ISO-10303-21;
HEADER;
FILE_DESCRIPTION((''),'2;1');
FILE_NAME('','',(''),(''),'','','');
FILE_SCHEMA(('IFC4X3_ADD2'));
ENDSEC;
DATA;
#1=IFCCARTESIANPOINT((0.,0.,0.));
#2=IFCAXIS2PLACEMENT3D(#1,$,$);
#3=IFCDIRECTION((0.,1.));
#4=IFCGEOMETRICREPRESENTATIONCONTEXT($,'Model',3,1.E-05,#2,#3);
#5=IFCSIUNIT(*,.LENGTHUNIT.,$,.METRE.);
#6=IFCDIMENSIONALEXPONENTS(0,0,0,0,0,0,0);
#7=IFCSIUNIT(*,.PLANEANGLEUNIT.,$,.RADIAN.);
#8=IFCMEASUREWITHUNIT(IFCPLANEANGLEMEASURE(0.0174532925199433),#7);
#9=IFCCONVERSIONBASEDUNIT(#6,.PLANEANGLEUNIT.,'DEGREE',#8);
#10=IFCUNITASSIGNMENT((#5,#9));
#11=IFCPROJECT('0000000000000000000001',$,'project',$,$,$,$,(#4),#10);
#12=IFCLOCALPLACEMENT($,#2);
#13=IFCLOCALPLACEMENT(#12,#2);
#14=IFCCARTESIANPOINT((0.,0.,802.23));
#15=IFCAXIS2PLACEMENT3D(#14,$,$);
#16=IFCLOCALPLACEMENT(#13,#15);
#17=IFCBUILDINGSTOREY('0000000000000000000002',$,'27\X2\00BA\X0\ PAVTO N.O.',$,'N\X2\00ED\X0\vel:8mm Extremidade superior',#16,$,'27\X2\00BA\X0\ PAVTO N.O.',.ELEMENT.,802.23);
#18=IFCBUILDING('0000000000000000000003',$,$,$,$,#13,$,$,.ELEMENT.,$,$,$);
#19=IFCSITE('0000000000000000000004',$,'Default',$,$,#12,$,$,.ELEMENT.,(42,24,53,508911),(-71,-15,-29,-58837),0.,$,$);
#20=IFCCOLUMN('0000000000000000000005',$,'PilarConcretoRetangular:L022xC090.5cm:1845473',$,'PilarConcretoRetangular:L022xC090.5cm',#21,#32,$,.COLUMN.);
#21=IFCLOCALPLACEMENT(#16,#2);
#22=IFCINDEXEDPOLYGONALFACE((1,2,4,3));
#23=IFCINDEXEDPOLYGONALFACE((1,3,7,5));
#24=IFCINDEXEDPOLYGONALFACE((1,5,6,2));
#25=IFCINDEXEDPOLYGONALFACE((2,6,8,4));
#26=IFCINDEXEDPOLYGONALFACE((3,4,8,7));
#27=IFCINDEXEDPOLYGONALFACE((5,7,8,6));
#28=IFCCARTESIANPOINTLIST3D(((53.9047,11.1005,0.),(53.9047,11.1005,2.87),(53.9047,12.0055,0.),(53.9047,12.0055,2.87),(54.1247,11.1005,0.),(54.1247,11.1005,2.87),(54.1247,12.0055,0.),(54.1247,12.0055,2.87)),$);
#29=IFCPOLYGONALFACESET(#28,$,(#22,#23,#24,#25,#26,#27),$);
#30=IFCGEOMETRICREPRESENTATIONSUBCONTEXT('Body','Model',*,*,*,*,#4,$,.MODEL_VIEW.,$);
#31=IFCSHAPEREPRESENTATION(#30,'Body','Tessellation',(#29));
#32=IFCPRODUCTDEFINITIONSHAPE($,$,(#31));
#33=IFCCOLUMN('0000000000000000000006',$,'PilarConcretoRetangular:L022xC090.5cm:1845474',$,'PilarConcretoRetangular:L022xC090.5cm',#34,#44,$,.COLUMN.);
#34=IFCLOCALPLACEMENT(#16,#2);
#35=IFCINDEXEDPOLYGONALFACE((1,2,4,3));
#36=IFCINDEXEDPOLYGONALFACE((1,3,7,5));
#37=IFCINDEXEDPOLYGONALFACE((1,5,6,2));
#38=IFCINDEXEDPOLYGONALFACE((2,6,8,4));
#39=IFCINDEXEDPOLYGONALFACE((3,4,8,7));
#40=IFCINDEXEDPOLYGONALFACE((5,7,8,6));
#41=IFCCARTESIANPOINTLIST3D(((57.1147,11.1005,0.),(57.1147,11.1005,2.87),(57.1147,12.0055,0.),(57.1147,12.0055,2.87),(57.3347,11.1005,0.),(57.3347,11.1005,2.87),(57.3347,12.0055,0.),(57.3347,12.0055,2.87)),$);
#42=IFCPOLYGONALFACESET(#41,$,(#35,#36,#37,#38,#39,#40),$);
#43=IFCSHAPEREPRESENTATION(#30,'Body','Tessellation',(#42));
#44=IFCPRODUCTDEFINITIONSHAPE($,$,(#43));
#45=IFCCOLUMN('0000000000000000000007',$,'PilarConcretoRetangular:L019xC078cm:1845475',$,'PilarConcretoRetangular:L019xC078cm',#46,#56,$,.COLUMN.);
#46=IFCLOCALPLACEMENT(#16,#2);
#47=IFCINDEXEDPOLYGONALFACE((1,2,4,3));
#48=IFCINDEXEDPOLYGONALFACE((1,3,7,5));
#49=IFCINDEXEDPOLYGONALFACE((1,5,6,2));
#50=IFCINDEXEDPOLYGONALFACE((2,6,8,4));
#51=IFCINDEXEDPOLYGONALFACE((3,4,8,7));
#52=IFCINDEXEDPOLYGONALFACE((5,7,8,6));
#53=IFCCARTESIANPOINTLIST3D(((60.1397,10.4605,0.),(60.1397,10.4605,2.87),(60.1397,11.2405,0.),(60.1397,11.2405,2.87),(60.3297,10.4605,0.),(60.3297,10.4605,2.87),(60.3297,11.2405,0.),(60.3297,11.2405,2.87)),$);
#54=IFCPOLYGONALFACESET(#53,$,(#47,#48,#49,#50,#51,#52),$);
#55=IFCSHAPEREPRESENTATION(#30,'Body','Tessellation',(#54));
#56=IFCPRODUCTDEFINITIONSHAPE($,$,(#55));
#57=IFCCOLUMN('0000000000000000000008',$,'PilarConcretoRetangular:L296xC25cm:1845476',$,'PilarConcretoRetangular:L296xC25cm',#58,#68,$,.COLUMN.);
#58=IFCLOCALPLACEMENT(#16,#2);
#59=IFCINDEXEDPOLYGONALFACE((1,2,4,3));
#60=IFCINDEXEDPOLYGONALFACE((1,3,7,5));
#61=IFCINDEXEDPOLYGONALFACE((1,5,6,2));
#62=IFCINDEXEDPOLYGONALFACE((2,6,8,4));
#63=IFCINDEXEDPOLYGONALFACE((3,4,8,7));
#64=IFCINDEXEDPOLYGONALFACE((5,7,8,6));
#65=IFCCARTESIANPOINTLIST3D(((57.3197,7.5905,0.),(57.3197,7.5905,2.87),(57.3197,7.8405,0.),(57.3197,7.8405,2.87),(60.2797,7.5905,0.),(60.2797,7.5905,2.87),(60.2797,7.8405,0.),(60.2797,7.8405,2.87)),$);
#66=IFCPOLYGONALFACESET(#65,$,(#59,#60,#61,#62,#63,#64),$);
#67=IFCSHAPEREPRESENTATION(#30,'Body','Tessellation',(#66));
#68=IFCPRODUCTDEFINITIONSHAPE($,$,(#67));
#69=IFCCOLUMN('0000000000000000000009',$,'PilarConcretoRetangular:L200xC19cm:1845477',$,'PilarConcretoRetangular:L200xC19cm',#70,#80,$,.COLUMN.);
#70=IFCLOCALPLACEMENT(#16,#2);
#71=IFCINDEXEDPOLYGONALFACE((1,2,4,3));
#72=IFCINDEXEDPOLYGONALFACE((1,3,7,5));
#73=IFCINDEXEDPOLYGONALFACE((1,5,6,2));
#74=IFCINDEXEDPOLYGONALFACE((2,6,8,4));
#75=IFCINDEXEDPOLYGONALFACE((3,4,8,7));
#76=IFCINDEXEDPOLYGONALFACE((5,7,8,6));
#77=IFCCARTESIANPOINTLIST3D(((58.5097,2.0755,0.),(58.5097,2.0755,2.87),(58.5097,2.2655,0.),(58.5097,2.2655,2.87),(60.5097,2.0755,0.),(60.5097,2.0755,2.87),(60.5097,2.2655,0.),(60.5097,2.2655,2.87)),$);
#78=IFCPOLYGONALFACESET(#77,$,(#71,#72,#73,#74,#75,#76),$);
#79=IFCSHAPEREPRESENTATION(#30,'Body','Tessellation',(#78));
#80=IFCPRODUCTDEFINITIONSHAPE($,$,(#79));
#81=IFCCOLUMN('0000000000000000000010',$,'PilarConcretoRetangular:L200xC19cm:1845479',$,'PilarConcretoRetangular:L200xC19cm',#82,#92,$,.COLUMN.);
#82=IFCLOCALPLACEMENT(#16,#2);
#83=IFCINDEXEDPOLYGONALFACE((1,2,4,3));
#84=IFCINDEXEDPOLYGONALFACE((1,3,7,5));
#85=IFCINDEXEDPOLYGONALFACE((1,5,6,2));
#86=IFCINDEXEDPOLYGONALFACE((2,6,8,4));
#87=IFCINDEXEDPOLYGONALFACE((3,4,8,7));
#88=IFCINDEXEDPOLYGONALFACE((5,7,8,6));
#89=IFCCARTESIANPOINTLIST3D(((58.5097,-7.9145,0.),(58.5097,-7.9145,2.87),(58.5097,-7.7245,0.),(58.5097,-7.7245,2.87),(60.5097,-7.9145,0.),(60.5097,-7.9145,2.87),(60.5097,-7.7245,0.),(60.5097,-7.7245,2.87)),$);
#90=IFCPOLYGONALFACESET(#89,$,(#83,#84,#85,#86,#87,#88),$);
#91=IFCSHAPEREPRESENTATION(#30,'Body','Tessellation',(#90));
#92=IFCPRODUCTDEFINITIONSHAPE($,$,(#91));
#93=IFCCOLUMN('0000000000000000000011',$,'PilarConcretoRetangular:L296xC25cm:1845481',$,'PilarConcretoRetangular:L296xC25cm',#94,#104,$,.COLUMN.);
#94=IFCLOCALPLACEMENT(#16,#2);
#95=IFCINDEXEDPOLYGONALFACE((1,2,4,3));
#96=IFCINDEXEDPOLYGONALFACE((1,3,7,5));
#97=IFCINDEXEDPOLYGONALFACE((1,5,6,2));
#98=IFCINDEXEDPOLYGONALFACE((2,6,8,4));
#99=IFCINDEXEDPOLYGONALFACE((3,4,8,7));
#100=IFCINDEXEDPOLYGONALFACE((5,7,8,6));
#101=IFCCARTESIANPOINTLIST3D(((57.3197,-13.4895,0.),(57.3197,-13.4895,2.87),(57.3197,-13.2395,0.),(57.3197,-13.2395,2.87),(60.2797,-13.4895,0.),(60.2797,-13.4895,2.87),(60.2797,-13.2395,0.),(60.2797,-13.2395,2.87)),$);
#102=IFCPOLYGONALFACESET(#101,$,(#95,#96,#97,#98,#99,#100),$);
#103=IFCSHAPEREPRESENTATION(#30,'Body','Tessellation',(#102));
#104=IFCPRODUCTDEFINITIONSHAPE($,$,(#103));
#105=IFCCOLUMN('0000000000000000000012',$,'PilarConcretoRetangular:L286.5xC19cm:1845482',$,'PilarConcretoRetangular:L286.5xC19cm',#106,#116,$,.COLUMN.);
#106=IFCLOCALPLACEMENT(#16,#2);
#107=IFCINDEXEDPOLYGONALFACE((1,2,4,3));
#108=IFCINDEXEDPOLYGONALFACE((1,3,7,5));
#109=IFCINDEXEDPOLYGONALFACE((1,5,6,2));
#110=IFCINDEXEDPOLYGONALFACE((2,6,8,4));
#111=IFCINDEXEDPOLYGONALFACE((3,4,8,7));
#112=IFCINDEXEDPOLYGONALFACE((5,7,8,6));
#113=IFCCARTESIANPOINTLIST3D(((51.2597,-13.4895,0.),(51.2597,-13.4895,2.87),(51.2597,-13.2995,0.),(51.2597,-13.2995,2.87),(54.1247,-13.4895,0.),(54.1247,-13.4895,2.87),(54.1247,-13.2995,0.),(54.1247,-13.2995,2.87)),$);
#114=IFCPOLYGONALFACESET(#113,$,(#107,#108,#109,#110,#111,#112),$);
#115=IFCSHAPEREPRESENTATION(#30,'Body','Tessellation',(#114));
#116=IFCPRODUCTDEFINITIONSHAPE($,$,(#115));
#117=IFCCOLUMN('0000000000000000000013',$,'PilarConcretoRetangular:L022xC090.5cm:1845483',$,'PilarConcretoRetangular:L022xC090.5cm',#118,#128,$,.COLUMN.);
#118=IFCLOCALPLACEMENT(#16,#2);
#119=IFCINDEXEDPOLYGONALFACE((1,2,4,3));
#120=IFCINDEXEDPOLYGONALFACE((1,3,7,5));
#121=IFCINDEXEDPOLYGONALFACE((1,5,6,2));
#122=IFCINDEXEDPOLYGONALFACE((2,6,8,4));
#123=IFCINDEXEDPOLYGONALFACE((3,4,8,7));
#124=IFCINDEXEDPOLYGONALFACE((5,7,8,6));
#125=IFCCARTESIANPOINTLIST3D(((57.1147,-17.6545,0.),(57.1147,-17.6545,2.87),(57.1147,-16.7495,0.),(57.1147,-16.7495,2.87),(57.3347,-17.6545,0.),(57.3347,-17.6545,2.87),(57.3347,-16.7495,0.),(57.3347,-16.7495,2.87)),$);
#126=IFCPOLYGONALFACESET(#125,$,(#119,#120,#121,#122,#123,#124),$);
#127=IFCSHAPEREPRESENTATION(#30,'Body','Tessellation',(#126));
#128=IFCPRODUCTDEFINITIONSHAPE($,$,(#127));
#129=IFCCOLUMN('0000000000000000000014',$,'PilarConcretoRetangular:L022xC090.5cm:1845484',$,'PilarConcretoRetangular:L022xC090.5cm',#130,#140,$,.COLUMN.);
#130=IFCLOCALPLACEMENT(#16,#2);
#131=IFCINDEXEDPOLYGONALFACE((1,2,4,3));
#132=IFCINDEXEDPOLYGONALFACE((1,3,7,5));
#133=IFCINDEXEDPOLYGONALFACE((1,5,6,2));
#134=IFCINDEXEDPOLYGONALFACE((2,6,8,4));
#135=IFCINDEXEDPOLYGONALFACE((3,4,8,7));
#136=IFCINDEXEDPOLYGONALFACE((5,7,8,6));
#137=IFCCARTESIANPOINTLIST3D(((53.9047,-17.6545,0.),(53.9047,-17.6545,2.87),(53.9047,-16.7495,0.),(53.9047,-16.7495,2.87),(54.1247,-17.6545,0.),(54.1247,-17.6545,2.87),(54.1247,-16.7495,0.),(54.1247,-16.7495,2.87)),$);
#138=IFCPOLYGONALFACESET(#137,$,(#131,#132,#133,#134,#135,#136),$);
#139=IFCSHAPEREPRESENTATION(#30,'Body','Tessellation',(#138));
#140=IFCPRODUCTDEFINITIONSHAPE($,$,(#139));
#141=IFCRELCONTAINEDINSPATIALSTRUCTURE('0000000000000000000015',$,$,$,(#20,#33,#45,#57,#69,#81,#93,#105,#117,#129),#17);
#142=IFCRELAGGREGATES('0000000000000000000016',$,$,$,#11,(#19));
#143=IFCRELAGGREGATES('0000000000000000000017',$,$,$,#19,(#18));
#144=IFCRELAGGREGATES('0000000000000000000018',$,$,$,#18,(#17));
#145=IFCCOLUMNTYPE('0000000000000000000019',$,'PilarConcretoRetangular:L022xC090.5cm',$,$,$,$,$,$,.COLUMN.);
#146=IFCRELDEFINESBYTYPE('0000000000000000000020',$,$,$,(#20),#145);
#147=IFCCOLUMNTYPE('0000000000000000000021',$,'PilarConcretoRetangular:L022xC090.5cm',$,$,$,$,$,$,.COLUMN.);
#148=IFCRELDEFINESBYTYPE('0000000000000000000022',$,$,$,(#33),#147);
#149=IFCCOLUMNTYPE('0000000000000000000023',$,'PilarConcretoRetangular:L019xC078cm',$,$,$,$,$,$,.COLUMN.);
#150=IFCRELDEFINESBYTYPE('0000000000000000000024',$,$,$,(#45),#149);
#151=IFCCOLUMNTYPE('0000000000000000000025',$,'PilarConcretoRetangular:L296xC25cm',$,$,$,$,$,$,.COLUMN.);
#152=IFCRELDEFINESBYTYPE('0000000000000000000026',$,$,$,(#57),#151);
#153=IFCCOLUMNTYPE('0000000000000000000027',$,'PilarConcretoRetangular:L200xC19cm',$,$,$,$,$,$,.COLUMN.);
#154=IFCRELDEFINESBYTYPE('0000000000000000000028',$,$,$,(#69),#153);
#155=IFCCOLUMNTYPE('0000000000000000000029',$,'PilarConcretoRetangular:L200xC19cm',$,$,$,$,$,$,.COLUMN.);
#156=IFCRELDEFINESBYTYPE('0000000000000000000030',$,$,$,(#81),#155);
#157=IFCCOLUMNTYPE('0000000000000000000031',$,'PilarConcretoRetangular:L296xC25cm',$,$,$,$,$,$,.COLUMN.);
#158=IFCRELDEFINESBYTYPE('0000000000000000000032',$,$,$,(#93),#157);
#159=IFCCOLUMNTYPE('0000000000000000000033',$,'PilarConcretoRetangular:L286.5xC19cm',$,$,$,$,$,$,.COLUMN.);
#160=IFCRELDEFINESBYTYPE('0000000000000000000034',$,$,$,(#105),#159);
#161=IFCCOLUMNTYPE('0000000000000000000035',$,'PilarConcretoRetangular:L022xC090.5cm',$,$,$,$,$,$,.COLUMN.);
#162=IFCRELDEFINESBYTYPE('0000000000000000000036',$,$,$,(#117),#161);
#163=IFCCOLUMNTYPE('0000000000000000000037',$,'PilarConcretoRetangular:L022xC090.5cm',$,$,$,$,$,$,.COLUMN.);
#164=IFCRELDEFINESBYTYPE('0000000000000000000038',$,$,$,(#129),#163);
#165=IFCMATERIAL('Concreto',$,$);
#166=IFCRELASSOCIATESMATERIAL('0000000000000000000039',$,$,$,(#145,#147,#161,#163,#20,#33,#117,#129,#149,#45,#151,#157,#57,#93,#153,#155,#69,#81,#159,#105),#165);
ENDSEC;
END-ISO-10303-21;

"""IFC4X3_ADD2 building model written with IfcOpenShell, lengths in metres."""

from ifc_helpers import new_model, entity, si_unit, converted_unit, direction, frame, frame_2d, origin, origin_2d_with_axis, place, context, subcontext, project, spatial, rectangle, extrude, source, transform, mapped, material, material_profile, profile_set, profile_usage, type_object, type_shapes, element, save


model = new_model("IFC4X3_ADD2")

# Units and contexts
model_context = context("Model", 3, precision=1e-05, world=origin(), true_north=direction((0.0, 1.0)))
body_context = subcontext(model_context, "Body", "Model", "MODEL_VIEW")
ifc_project = project(units=[si_unit("LENGTHUNIT", "METRE"), converted_unit("PLANEANGLEUNIT", "DEGREE", entity("IfcPlaneAngleMeasure", 0.0174532925199433), si_unit("PLANEANGLEUNIT", "RADIAN"), dimensions=[0, 0, 0, 0, 0, 0, 0])], contexts=[model_context])

# Site, building, storey
site_placement = place(None, origin())
site = spatial("IfcSite", under=ifc_project, at=site_placement, Name="Default", CompositionType="ELEMENT", RefLatitude=(42, 24, 53, 508911), RefLongitude=(-71, -15, -29, -58837), RefElevation=0.0)
building_placement = place(site_placement, origin())
building = spatial("IfcBuilding", under=site, at=building_placement, CompositionType="ELEMENT")
storey_placement = place(building_placement, frame((0.0, 0.0, 802.23)))
storey = spatial("IfcBuildingStorey", under=building, at=storey_placement, Name="27º PAVTO N.O.", ObjectType="Nível:8mm Extremidade superior", LongName="27º PAVTO N.O.", CompositionType="ELEMENT", Elevation=802.23)

# Columns
ifc_material = material(Name="Concreto")
ifc_material_profile_1 = material_profile(ifc_material, rectangle(XDim=0.22, YDim=0.905, at=frame_2d((0.0, 0.0), x_axis=(1.0, 0.0))), Name="L022xC090.5cm")
ifc_profile_set_1 = profile_set([ifc_material_profile_1], Name="L022xC090.5cm")
ifc_profile_usage_1 = profile_usage(ifc_profile_set_1)
ifc_material_profile_2 = material_profile(ifc_material, rectangle(XDim=2.0, YDim=0.19, at=frame_2d((0.0, 0.0), x_axis=(1.0, 0.0))), Name="L200xC19cm")
ifc_profile_set_2 = profile_set([ifc_material_profile_2], Name="L200xC19cm")
ifc_profile_usage_2 = profile_usage(ifc_profile_set_2)
ifc_material_profile_3 = material_profile(ifc_material, rectangle(XDim=2.96, YDim=0.25, at=frame_2d((0.0, 0.0), x_axis=(1.0, 0.0))), Name="L296xC25cm")
ifc_profile_set_3 = profile_set([ifc_material_profile_3], Name="L296xC25cm")
ifc_profile_usage_3 = profile_usage(ifc_profile_set_3)
ifc_material_profile_4 = material_profile(ifc_material, rectangle(XDim=2.865, YDim=0.19, at=frame_2d((0.0, 0.0), x_axis=(1.0, 0.0))), Name="L286.5xC19cm")
ifc_profile_set_4 = profile_set([ifc_material_profile_4], Name="L286.5xC19cm")
ifc_profile_usage_4 = profile_usage(ifc_profile_set_4)
column_type_1 = type_object("IfcColumnType", Name="PilarConcretoRetangular:L022xC090.5cm", PredefinedType="COLUMN", material=ifc_profile_set_1)
shared_shape_1 = source(origin(), body_context, "Body", "SweptSolid", [
    extrude(rectangle(XDim=0.22, YDim=0.905, at=frame_2d((0.0, 0.0), x_axis=(1.0, 0.0))), frame((54.0147, 11.553, 802.23)), (0.0, 0.0, 1.0), 2.87),
])
type_shapes(column_type_1, [shared_shape_1])
column_1_placement = place(storey_placement, frame((0.0, 0.0, -802.23)))
element("IfcColumn", 1, at=column_1_placement, inside=storey, type_object=column_type_1, material=ifc_profile_usage_1, Name="PilarConcretoRetangular:L022xC090.5cm:1845473", ObjectType="PilarConcretoRetangular:L022xC090.5cm", PredefinedType="COLUMN", context=body_context, shape_type="MappedRepresentation", body=[
    mapped(shared_shape_1, transform((0.0, 0.0, 0.0), scale=1.0)),
])
column_type_2 = type_object("IfcColumnType", Name="PilarConcretoRetangular:L022xC090.5cm", PredefinedType="COLUMN", material=ifc_profile_set_1)
shared_shape_2 = source(origin(), body_context, "Body", "SweptSolid", [
    extrude(rectangle(XDim=0.22, YDim=0.905, at=frame_2d((0.0, 0.0), x_axis=(1.0, 0.0))), frame((57.2247, 11.553, 802.23)), (0.0, 0.0, 1.0), 2.87),
])
type_shapes(column_type_2, [shared_shape_2])
column_2_placement = place(storey_placement, frame((0.0, 0.0, -802.23)))
element("IfcColumn", 2, at=column_2_placement, inside=storey, type_object=column_type_2, material=ifc_profile_usage_1, Name="PilarConcretoRetangular:L022xC090.5cm:1845474", ObjectType="PilarConcretoRetangular:L022xC090.5cm", PredefinedType="COLUMN", context=body_context, shape_type="MappedRepresentation", body=[
    mapped(shared_shape_2, transform((0.0, 0.0, 0.0), scale=1.0)),
])
ifc_material_profile_5 = material_profile(ifc_material, rectangle(XDim=0.19, YDim=0.78, at=frame_2d((0.0, 0.0), x_axis=(1.0, 0.0))), Name="L019xC078cm")
ifc_profile_set_5 = profile_set([ifc_material_profile_5], Name="L019xC078cm")
ifc_profile_usage_5 = profile_usage(ifc_profile_set_5)
column_type_3 = type_object("IfcColumnType", Name="PilarConcretoRetangular:L019xC078cm", PredefinedType="COLUMN", material=ifc_profile_set_5)
shared_shape_3 = source(origin(), body_context, "Body", "SweptSolid", [
    extrude(rectangle(XDim=0.19, YDim=0.78, at=frame_2d((0.0, 0.0), x_axis=(1.0, 0.0))), frame((60.2347, 10.8505, 802.23)), (0.0, 0.0, 1.0), 2.87),
])
type_shapes(column_type_3, [shared_shape_3])
column_3_placement = place(storey_placement, frame((0.0, 0.0, -802.23)))
element("IfcColumn", 3, at=column_3_placement, inside=storey, type_object=column_type_3, material=ifc_profile_usage_5, Name="PilarConcretoRetangular:L019xC078cm:1845475", ObjectType="PilarConcretoRetangular:L019xC078cm", PredefinedType="COLUMN", context=body_context, shape_type="MappedRepresentation", body=[
    mapped(shared_shape_3, transform((0.0, 0.0, 0.0), scale=1.0)),
])
column_type_4 = type_object("IfcColumnType", Name="PilarConcretoRetangular:L296xC25cm", PredefinedType="COLUMN", material=ifc_profile_set_3)
shared_shape_4 = source(origin(), body_context, "Body", "SweptSolid", [
    extrude(rectangle(XDim=2.96, YDim=0.25, at=frame_2d((0.0, 0.0), x_axis=(1.0, 0.0))), frame((58.7997, 7.7155, 802.23), z_axis=(0.0, 0.0, 1.0), x_axis=(-1.0, 0.0, 0.0)), (0.0, 0.0, 1.0), 2.87),
])
type_shapes(column_type_4, [shared_shape_4])
column_4_placement = place(storey_placement, frame((0.0, 0.0, -802.23)))
element("IfcColumn", 4, at=column_4_placement, inside=storey, type_object=column_type_4, material=ifc_profile_usage_3, Name="PilarConcretoRetangular:L296xC25cm:1845476", ObjectType="PilarConcretoRetangular:L296xC25cm", PredefinedType="COLUMN", context=body_context, shape_type="MappedRepresentation", body=[
    mapped(shared_shape_4, transform((0.0, 0.0, 0.0), scale=1.0)),
])
column_type_5 = type_object("IfcColumnType", Name="PilarConcretoRetangular:L200xC19cm", PredefinedType="COLUMN", material=ifc_profile_set_2)
shared_shape_5 = source(origin(), body_context, "Body", "SweptSolid", [
    extrude(rectangle(XDim=2.0, YDim=0.19, at=origin_2d_with_axis()), frame((59.5097, 2.1705, 802.23), z_axis=(0.0, 0.0, 1.0), x_axis=(-1.0, 0.0, 0.0)), (0.0, 0.0, 1.0), 2.87),
])
type_shapes(column_type_5, [shared_shape_5])
column_5_placement = place(storey_placement, frame((0.0, 0.0, -802.23)))
element("IfcColumn", 5, at=column_5_placement, inside=storey, type_object=column_type_5, material=ifc_profile_usage_2, Name="PilarConcretoRetangular:L200xC19cm:1845477", ObjectType="PilarConcretoRetangular:L200xC19cm", PredefinedType="COLUMN", context=body_context, shape_type="MappedRepresentation", body=[
    mapped(shared_shape_5, transform((0.0, 0.0, 0.0), scale=1.0)),
])
column_type_6 = type_object("IfcColumnType", Name="PilarConcretoRetangular:L200xC19cm", PredefinedType="COLUMN", material=ifc_profile_set_2)
shared_shape_6 = source(origin(), body_context, "Body", "SweptSolid", [
    extrude(rectangle(XDim=2.0, YDim=0.19, at=origin_2d_with_axis()), frame((59.5097, -7.8195, 802.23), z_axis=(0.0, 0.0, 1.0), x_axis=(-1.0, 0.0, 0.0)), (0.0, 0.0, 1.0), 2.87),
])
type_shapes(column_type_6, [shared_shape_6])
column_6_placement = place(storey_placement, frame((0.0, 0.0, -802.23)))
element("IfcColumn", 6, at=column_6_placement, inside=storey, type_object=column_type_6, material=ifc_profile_usage_2, Name="PilarConcretoRetangular:L200xC19cm:1845479", ObjectType="PilarConcretoRetangular:L200xC19cm", PredefinedType="COLUMN", context=body_context, shape_type="MappedRepresentation", body=[
    mapped(shared_shape_6, transform((0.0, 0.0, 0.0), scale=1.0)),
])
column_type_7 = type_object("IfcColumnType", Name="PilarConcretoRetangular:L296xC25cm", PredefinedType="COLUMN", material=ifc_profile_set_3)
shared_shape_7 = source(origin(), body_context, "Body", "SweptSolid", [
    extrude(rectangle(XDim=2.96, YDim=0.25, at=frame_2d((0.0, 0.0), x_axis=(1.0, 0.0))), frame((58.7997, -13.3645, 802.23), z_axis=(0.0, 0.0, 1.0), x_axis=(-1.0, 0.0, 0.0)), (0.0, 0.0, 1.0), 2.87),
])
type_shapes(column_type_7, [shared_shape_7])
column_7_placement = place(storey_placement, frame((0.0, 0.0, -802.23)))
element("IfcColumn", 7, at=column_7_placement, inside=storey, type_object=column_type_7, material=ifc_profile_usage_3, Name="PilarConcretoRetangular:L296xC25cm:1845481", ObjectType="PilarConcretoRetangular:L296xC25cm", PredefinedType="COLUMN", context=body_context, shape_type="MappedRepresentation", body=[
    mapped(shared_shape_7, transform((0.0, 0.0, 0.0), scale=1.0)),
])
column_type_8 = type_object("IfcColumnType", Name="PilarConcretoRetangular:L286.5xC19cm", PredefinedType="COLUMN", material=ifc_profile_set_4)
shared_shape_8 = source(origin(), body_context, "Body", "SweptSolid", [
    extrude(rectangle(XDim=2.865, YDim=0.19, at=frame_2d((0.0, 0.0), x_axis=(1.0, 0.0))), frame((52.6922, -13.3945, 802.23), z_axis=(0.0, 0.0, 1.0), x_axis=(-1.0, 0.0, 0.0)), (0.0, 0.0, 1.0), 2.87),
])
type_shapes(column_type_8, [shared_shape_8])
column_8_placement = place(storey_placement, frame((0.0, 0.0, -802.23)))
element("IfcColumn", 8, at=column_8_placement, inside=storey, type_object=column_type_8, material=ifc_profile_usage_4, Name="PilarConcretoRetangular:L286.5xC19cm:1845482", ObjectType="PilarConcretoRetangular:L286.5xC19cm", PredefinedType="COLUMN", context=body_context, shape_type="MappedRepresentation", body=[
    mapped(shared_shape_8, transform((0.0, 0.0, 0.0), scale=1.0)),
])
column_type_9 = type_object("IfcColumnType", Name="PilarConcretoRetangular:L022xC090.5cm", PredefinedType="COLUMN", material=ifc_profile_set_1)
shared_shape_9 = source(origin(), body_context, "Body", "SweptSolid", [
    extrude(rectangle(XDim=0.22, YDim=0.905, at=frame_2d((0.0, 0.0), x_axis=(1.0, 0.0))), frame((57.2247, -17.202, 802.23), z_axis=(0.0, 0.0, 1.0), x_axis=(-1.0, 0.0, 0.0)), (0.0, 0.0, 1.0), 2.87),
])
type_shapes(column_type_9, [shared_shape_9])
column_9_placement = place(storey_placement, frame((0.0, 0.0, -802.23)))
element("IfcColumn", 9, at=column_9_placement, inside=storey, type_object=column_type_9, material=ifc_profile_usage_1, Name="PilarConcretoRetangular:L022xC090.5cm:1845483", ObjectType="PilarConcretoRetangular:L022xC090.5cm", PredefinedType="COLUMN", context=body_context, shape_type="MappedRepresentation", body=[
    mapped(shared_shape_9, transform((0.0, 0.0, 0.0), scale=1.0)),
])
column_type_10 = type_object("IfcColumnType", Name="PilarConcretoRetangular:L022xC090.5cm", PredefinedType="COLUMN", material=ifc_profile_set_1)
shared_shape_10 = source(origin(), body_context, "Body", "SweptSolid", [
    extrude(rectangle(XDim=0.22, YDim=0.905, at=frame_2d((0.0, 0.0), x_axis=(1.0, 0.0))), frame((54.0147, -17.202, 802.23), z_axis=(0.0, 0.0, 1.0), x_axis=(-1.0, 0.0, 0.0)), (0.0, 0.0, 1.0), 2.87),
])
type_shapes(column_type_10, [shared_shape_10])
column_10_placement = place(storey_placement, frame((0.0, 0.0, -802.23)))
element("IfcColumn", 10, at=column_10_placement, inside=storey, type_object=column_type_10, material=ifc_profile_usage_1, Name="PilarConcretoRetangular:L022xC090.5cm:1845484", ObjectType="PilarConcretoRetangular:L022xC090.5cm", PredefinedType="COLUMN", context=body_context, shape_type="MappedRepresentation", body=[
    mapped(shared_shape_10, transform((0.0, 0.0, 0.0), scale=1.0)),
])

save(model, "model.ifc")
